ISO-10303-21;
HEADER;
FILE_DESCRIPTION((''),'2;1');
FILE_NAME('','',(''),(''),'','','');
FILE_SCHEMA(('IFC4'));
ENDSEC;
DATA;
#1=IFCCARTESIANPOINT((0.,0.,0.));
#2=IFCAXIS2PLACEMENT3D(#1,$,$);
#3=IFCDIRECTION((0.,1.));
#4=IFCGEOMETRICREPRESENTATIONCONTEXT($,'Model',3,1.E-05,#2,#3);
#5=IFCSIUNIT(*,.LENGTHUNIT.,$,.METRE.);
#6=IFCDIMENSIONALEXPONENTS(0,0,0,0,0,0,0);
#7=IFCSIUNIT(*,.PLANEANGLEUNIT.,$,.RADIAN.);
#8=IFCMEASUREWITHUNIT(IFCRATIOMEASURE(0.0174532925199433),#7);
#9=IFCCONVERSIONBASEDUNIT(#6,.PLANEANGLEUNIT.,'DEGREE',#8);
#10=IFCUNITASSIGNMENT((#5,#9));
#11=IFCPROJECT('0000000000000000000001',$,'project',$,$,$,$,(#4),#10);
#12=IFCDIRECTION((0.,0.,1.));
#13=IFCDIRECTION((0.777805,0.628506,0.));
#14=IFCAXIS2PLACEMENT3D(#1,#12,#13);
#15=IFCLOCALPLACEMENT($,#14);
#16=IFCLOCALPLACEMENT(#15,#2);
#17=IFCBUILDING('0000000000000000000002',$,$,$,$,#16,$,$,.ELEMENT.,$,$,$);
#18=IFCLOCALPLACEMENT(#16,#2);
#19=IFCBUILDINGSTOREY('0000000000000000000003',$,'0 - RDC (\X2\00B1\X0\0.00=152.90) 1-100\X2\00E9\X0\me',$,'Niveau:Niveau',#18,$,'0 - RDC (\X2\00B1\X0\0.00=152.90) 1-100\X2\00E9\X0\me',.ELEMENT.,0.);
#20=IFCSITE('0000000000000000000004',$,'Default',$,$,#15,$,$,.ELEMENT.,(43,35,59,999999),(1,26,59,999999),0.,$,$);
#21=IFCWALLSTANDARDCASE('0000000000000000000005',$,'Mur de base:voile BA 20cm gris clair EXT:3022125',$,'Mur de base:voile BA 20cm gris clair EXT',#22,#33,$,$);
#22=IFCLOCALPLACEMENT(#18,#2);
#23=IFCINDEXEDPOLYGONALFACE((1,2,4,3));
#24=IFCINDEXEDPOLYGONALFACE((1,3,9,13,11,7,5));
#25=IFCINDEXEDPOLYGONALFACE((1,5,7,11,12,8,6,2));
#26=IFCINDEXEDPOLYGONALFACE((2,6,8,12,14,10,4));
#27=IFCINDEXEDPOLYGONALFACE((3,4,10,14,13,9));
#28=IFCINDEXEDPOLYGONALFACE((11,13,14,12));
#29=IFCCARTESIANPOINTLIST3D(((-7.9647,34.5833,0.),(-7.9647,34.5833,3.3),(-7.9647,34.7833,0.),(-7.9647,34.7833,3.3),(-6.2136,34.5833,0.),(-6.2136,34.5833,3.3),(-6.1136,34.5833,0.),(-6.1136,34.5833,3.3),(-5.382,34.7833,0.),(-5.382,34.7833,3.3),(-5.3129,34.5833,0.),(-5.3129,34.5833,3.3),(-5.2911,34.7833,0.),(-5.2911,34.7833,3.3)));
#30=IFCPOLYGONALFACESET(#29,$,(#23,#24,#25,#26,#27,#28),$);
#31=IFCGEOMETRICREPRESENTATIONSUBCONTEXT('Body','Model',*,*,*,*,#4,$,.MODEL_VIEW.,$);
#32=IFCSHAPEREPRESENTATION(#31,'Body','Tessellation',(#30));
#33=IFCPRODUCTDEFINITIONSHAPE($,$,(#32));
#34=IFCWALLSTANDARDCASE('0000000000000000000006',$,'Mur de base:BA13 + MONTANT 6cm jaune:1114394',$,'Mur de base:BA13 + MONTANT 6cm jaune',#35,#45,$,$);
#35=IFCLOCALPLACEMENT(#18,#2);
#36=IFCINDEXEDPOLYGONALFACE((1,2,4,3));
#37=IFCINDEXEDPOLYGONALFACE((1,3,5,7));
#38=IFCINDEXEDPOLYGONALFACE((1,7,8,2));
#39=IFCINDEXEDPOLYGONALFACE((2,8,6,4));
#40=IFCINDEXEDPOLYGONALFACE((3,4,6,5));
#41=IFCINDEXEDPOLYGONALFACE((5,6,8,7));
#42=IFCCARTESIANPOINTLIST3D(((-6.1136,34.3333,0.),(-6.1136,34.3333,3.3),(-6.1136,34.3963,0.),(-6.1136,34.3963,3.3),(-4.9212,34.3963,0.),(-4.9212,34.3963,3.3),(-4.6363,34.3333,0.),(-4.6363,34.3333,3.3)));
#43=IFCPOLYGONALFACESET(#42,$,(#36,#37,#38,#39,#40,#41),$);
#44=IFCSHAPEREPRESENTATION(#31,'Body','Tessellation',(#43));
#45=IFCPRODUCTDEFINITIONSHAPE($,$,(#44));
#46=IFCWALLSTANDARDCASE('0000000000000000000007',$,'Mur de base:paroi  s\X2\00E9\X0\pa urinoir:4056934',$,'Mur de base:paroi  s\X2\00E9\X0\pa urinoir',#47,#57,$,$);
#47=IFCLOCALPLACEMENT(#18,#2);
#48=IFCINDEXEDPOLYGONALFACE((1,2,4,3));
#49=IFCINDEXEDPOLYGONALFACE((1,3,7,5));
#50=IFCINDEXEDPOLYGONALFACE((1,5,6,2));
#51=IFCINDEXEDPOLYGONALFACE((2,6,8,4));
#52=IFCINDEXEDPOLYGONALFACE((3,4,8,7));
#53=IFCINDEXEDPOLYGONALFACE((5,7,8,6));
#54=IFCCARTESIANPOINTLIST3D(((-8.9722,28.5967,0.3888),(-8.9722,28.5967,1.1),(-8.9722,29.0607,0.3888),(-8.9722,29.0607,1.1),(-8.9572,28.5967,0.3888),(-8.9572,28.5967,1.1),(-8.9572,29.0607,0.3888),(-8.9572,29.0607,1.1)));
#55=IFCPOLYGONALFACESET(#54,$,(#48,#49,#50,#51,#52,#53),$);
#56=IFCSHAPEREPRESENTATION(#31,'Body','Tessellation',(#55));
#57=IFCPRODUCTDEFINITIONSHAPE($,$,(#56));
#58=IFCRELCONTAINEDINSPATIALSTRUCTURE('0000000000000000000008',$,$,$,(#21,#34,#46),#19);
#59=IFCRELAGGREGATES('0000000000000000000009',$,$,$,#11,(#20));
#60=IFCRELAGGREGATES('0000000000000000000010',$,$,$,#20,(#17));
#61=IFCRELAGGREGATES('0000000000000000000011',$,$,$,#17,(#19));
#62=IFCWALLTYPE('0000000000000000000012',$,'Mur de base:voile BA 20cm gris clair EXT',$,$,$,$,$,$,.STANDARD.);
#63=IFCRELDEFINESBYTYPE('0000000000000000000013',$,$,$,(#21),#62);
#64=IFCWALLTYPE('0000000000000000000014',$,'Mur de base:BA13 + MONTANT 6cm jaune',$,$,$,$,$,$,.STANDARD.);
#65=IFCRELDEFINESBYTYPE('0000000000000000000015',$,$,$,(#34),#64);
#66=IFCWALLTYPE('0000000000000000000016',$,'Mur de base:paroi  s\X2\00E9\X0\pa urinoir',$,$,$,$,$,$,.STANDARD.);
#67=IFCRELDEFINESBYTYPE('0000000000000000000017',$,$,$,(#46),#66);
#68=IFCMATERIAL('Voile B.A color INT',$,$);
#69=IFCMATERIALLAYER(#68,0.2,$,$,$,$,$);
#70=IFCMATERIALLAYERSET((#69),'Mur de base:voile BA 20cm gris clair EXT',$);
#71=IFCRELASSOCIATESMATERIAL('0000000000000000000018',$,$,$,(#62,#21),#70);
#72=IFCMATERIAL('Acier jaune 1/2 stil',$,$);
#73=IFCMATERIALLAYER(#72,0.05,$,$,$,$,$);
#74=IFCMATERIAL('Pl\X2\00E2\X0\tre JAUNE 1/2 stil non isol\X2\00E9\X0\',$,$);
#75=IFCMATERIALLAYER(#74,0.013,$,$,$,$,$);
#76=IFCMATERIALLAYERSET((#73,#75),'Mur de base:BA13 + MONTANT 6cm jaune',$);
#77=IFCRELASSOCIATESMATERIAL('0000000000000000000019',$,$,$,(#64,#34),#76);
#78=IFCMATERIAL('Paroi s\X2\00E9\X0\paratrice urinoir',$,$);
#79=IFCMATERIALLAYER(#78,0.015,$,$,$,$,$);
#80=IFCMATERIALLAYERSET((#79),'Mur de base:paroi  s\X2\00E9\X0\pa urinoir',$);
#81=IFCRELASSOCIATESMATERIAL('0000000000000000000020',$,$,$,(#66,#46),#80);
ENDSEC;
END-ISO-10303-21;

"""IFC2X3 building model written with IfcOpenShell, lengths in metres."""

from ifc_helpers import new_model, entity, si_unit, converted_unit, direction, frame, frame_2d, origin, place, context, subcontext, project, spatial, polyline, rectangle, outline, extrude, clip, bounded_halfspace, material, layer, layer_set, layer_usage, type_object, element, save


model = new_model("IFC2X3")

# Units and contexts
model_context = context("Model", 3, precision=1e-05, world=origin(), true_north=direction((0.0, 1.0)))
body_context = subcontext(model_context, "Body", "Model", "MODEL_VIEW")
ifc_project = project(units=[si_unit("LENGTHUNIT", "METRE"), converted_unit("PLANEANGLEUNIT", "DEGREE", entity("IfcRatioMeasure", 0.0174532925199433), si_unit("PLANEANGLEUNIT", "RADIAN"), dimensions=[0, 0, 0, 0, 0, 0, 0])], contexts=[model_context])

# Site, building, storey
site_placement = place(None, frame((0.0, 0.0, 0.0), z_axis=(0.0, 0.0, 1.0), x_axis=(0.777805, 0.628506, 0.0)))
site = spatial("IfcSite", under=ifc_project, at=site_placement, Name="Default", CompositionType="ELEMENT", RefLatitude=(43, 35, 59, 999999), RefLongitude=(1, 26, 59, 999999), RefElevation=0.0)
building_placement = place(site_placement, origin())
building = spatial("IfcBuilding", under=site, at=building_placement, CompositionType="ELEMENT")
storey_placement = place(building_placement, origin())
storey = spatial("IfcBuildingStorey", under=building, at=storey_placement, Name="0 - RDC (±0.00=152.90) 1-100éme", ObjectType="Niveau:Niveau", LongName="0 - RDC (±0.00=152.90) 1-100éme", CompositionType="ELEMENT", Elevation=0.0)

# Shared definitions
ifc_material_1 = material(Name="Voile B.A color INT")
ifc_layer_1 = layer(ifc_material_1, 0.2)
ifc_layer_set_1 = layer_set([ifc_layer_1], Name="Mur de base:voile BA 20cm gris clair EXT")
wall_type_1 = type_object("IfcWallType", Name="Mur de base:voile BA 20cm gris clair EXT", PredefinedType="STANDARD", material=ifc_layer_set_1)

# Walls
ifc_layer_usage_1 = layer_usage(ifc_layer_set_1, "AXIS2", "NEGATIVE", 0.1)
wall_1_placement = place(storey_placement, frame((-7.9647, 34.6833, 0.0)))
element("IfcWallStandardCase", 1, at=wall_1_placement, inside=storey, type_object=wall_type_1, material=ifc_layer_usage_1, Name="Mur de base:voile BA 20cm gris clair EXT:3022125", ObjectType="Mur de base:voile BA 20cm gris clair EXT", context=body_context, shape_type="SweptSolid", body=[
    extrude(outline(polyline([(2.6518, -0.1), (2.6736, 0.1), (2.5827, 0.1), (0.0, 0.1), (0.0, -0.1), (1.7512, -0.1), (1.8512, -0.1), (2.6518, -0.1)])), origin(), (0.0, 0.0, 1.0), 3.3),
])
ifc_material_2 = material(Name="Acier jaune 1/2 stil")
ifc_layer_2 = layer(ifc_material_2, 0.05)
ifc_material_3 = material(Name="Plâtre JAUNE 1/2 stil non isolé")
ifc_layer_3 = layer(ifc_material_3, 0.013)
ifc_layer_set_2 = layer_set([ifc_layer_2, ifc_layer_3], Name="Mur de base:BA13 + MONTANT 6cm jaune")
ifc_layer_usage_2 = layer_usage(ifc_layer_set_2, "AXIS2", "NEGATIVE", 0.0315)
wall_type_2 = type_object("IfcWallType", Name="Mur de base:BA13 + MONTANT 6cm jaune", PredefinedType="STANDARD", material=ifc_layer_set_2)
wall_2_placement = place(storey_placement, frame((-6.1136, 34.3648, 0.0)))
element("IfcWallStandardCase", 2, at=wall_2_placement, inside=storey, type_object=wall_type_2, material=ifc_layer_usage_2, Name="Mur de base:BA13 + MONTANT 6cm jaune:1114394", ObjectType="Mur de base:BA13 + MONTANT 6cm jaune", context=body_context, shape_type="Clipping", body=[
    clip(extrude(rectangle(XDim=1.4773, YDim=0.063, at=frame_2d((0.7386, 0.0), x_axis=(-1.0, 0.0))), origin(), (0.0, 0.0, 1.0), 3.3), bounded_halfspace(frame((1.4773, -0.0315, 3.3), z_axis=(-0.2159, -0.976415, 0.0), x_axis=(0.976415, -0.2159, 0.0)), True, frame((1.4773, -0.0315, 3.3), z_axis=(-0.2159, -0.976415, 0.0), x_axis=(0.976415, -0.2159, 0.0)), polyline([(0.0, 0.0), (-0.2918, 0.0), (-0.2918, -3.3), (0.0, -3.3), (0.0, 0.0)]))),
])
ifc_material_4 = material(Name="Paroi séparatrice urinoir")
ifc_layer_4 = layer(ifc_material_4, 0.015)
ifc_layer_set_3 = layer_set([ifc_layer_4], Name="Mur de base:paroi  sépa urinoir")
ifc_layer_usage_3 = layer_usage(ifc_layer_set_3, "AXIS2", "NEGATIVE", 0.0075)
wall_type_3 = type_object("IfcWallType", Name="Mur de base:paroi  sépa urinoir", PredefinedType="STANDARD", material=ifc_layer_set_3)
wall_3_placement = place(storey_placement, frame((-8.9647, 28.5967, 0.3888), z_axis=(0.0, 0.0, 1.0), x_axis=(0.0, 1.0, 0.0)))
element("IfcWallStandardCase", 3, at=wall_3_placement, inside=storey, type_object=wall_type_3, material=ifc_layer_usage_3, Name="Mur de base:paroi  sépa urinoir:4056934", ObjectType="Mur de base:paroi  sépa urinoir", context=body_context, shape_type="SweptSolid", body=[
    extrude(rectangle(XDim=0.464, YDim=0.015, at=frame_2d((0.232, 0.0), x_axis=(-1.0, 0.0))), origin(), (0.0, 0.0, 1.0), 0.7112),
])

save(model, "model.ifc")
